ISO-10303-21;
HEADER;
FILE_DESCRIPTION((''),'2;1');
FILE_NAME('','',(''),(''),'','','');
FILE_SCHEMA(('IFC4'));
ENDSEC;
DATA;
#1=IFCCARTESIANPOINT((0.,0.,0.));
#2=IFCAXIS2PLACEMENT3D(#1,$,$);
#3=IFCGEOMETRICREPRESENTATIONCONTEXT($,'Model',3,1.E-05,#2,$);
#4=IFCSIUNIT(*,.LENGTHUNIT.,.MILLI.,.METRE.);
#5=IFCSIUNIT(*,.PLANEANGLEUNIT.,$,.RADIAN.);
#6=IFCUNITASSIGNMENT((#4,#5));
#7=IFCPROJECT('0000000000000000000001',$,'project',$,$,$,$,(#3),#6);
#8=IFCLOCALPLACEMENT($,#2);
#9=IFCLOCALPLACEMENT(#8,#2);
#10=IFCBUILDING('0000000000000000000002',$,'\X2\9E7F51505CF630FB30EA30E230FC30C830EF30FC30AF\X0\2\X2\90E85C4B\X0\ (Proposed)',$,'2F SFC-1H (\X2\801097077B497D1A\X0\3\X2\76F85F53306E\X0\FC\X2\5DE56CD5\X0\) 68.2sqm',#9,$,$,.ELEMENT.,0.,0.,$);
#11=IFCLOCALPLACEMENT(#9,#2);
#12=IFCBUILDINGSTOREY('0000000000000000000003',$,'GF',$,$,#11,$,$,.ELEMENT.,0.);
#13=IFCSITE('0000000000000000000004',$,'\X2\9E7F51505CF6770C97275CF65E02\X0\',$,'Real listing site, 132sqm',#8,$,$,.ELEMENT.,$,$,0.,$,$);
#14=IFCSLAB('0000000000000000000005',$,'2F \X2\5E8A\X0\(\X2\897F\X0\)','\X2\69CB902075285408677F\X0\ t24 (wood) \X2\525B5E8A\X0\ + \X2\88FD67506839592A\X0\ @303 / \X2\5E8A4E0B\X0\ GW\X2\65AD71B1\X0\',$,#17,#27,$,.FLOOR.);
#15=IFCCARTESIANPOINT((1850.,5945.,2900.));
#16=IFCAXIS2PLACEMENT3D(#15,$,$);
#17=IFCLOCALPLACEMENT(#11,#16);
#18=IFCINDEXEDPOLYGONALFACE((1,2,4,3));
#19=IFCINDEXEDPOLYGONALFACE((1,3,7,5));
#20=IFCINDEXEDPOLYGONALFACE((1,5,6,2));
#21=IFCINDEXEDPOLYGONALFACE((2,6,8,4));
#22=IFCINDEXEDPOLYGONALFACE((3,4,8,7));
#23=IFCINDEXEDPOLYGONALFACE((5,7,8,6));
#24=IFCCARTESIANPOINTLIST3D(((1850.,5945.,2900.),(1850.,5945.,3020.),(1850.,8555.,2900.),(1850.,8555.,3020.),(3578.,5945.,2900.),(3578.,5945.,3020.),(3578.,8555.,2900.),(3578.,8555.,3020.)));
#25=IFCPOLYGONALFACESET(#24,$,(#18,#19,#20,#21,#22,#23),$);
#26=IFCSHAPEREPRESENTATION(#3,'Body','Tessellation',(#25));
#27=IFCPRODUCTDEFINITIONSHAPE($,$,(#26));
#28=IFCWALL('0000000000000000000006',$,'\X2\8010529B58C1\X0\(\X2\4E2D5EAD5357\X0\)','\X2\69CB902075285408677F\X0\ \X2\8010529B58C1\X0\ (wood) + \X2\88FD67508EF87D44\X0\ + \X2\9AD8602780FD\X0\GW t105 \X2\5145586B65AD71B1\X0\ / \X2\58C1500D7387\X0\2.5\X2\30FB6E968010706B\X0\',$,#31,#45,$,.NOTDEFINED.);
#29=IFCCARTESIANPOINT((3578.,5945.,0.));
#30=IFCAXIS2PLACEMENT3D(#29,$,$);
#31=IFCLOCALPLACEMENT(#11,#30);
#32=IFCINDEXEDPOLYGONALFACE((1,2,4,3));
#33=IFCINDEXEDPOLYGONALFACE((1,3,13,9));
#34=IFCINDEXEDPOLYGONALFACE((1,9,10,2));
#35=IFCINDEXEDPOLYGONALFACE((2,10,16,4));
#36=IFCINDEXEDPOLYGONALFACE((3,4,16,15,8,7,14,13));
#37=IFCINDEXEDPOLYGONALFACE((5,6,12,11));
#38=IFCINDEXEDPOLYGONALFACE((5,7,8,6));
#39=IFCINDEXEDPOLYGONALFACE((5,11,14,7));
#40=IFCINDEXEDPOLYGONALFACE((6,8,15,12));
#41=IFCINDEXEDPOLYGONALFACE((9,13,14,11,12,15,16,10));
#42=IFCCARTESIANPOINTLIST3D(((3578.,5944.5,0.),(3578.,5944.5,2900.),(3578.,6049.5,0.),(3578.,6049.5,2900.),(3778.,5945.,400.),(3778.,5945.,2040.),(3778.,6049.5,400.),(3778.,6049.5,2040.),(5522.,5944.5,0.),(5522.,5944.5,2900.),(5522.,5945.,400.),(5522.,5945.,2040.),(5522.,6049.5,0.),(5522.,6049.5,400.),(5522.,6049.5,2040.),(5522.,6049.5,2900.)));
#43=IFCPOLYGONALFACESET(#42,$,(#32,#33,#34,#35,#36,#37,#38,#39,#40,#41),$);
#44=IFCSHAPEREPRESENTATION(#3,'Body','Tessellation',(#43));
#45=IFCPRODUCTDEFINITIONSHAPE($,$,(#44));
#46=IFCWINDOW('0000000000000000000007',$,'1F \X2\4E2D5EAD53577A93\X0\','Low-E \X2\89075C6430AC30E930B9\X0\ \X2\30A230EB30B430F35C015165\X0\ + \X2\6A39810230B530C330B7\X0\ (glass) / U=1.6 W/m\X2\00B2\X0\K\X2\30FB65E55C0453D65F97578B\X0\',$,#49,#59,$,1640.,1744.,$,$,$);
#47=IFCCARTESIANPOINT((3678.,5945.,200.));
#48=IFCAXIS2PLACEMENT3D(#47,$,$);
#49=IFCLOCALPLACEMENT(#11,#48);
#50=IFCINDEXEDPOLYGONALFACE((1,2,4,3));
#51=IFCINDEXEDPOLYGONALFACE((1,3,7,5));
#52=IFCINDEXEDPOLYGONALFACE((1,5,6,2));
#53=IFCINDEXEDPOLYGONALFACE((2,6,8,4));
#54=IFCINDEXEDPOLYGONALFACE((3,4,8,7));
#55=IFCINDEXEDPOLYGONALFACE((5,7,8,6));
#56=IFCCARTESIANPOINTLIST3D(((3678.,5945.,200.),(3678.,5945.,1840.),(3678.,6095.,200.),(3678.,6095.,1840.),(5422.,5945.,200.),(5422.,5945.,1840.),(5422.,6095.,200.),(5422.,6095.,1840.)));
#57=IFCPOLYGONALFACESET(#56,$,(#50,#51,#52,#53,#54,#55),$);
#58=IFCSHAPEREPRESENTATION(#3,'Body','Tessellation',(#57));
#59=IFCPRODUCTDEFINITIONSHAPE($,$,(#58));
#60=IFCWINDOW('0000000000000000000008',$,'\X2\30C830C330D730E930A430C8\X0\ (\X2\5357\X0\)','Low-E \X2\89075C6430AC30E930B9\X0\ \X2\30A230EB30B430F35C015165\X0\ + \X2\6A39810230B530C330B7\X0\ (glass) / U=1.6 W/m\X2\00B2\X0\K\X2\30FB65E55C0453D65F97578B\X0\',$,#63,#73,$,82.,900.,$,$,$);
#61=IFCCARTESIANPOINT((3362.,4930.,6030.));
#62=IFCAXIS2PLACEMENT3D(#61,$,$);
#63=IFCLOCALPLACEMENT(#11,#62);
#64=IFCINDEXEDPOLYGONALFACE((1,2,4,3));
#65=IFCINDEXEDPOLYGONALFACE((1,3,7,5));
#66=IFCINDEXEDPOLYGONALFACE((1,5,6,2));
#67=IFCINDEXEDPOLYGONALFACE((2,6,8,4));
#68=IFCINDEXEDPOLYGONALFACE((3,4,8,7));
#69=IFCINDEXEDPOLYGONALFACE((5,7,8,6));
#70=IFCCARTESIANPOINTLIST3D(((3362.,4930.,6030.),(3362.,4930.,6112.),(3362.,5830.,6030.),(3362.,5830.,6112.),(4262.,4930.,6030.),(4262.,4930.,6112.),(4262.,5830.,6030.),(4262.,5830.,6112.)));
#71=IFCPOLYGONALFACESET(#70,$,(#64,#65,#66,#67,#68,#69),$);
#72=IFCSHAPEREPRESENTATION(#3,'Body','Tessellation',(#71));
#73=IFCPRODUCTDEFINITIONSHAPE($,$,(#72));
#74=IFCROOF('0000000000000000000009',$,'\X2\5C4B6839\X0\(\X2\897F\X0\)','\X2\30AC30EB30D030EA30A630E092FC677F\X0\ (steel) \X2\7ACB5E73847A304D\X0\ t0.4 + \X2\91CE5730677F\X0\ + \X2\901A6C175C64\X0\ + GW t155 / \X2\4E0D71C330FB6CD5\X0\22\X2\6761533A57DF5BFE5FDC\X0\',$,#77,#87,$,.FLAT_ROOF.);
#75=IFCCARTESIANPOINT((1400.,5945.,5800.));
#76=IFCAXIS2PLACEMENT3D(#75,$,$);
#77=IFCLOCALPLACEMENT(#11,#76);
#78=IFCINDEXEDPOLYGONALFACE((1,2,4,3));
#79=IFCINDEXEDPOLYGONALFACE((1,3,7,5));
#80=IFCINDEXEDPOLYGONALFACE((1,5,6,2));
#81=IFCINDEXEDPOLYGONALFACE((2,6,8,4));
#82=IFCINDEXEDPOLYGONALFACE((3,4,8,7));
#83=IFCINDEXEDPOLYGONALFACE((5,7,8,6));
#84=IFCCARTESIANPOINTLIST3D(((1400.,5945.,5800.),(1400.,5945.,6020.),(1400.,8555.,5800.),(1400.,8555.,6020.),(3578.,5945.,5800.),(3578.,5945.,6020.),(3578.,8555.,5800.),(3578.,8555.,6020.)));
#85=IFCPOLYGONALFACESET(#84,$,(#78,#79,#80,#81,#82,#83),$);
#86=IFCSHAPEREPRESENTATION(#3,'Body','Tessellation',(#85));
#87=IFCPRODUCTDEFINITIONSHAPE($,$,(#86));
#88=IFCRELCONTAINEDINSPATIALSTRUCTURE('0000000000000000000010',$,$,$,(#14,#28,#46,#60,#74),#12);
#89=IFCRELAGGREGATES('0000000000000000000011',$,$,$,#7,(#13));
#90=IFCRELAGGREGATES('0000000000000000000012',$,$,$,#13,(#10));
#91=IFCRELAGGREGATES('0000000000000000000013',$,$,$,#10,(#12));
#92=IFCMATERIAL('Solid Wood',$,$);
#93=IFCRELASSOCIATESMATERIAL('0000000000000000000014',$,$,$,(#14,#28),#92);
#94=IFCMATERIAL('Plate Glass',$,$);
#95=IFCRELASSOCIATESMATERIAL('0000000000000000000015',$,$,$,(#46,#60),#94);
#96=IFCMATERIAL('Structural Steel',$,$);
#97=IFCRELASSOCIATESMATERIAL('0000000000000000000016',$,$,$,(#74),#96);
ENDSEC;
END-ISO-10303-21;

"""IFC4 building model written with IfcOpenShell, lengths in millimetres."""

from ifc_helpers import new_model, si_unit, frame, frame_2d, origin, place, context, project, spatial, rectangle, extrude, material, element, fill, save


model = new_model("IFC4")

# Units and contexts
model_context = context("Model", 3, precision=1e-05, world=origin())
ifc_project = project(units=[si_unit("LENGTHUNIT", "METRE", prefix="MILLI"), si_unit("PLANEANGLEUNIT", "RADIAN")], contexts=[model_context])

# Site, building, storey
site_placement = place(None, origin())
site = spatial("IfcSite", under=ifc_project, at=site_placement, Name="鹿児島県霧島市", ObjectType="Real listing site, 132sqm", CompositionType="ELEMENT", RefElevation=0.0)
building_placement = place(site_placement, origin())
building = spatial("IfcBuilding", under=site, at=building_placement, Name="鹿児島・リモートワーク2部屋 (Proposed)", ObjectType="2F SFC-1H (耐震等級3相当のFC工法) 68.2sqm", CompositionType="ELEMENT", ElevationOfRefHeight=0.0, ElevationOfTerrain=0.0)
storey_placement = place(building_placement, origin())
storey = spatial("IfcBuildingStorey", under=building, at=storey_placement, Name="GF", CompositionType="ELEMENT", Elevation=0.0)

# Shared definitions
ifc_material_1 = material(Name="Solid Wood")

# Slab
slab_1_placement = place(storey_placement, frame((1850.0, 5945.0, 2900.0)))
element("IfcSlab", 1, at=slab_1_placement, inside=storey, material=ifc_material_1, Name="2F 床(西)", Description="構造用合板 t24 (wood) 剛床 + 製材根太 @303 / 床下 GW断熱", PredefinedType="FLOOR", context=model_context, shape_type="SweptSolid", body=[
    extrude(rectangle(XDim=1728.0, YDim=2610.0, at=frame_2d((864.0, 1305.0))), frame((1850.0, 5945.0, 2900.0)), (0.0, 0.0, 1.0), 120.0),
])

# Wall, opening, window
wall_placement = place(storey_placement, frame((3578.0, 5945.0, 0.0)))
wall = element("IfcWall", 2, at=wall_placement, inside=storey, material=ifc_material_1, Name="耐力壁(中庭南)", Description="構造用合板 耐力壁 (wood) + 製材軸組 + 高性能GW t105 充填断熱 / 壁倍率2.5・準耐火", PredefinedType="NOTDEFINED", context=model_context, shape_type="SweptSolid", body=[
    extrude(rectangle(XDim=1944.0, YDim=105.0, at=frame_2d((972.0, 52.0))), frame((3578.0, 5945.0, 0.0)), (0.0, 0.0, 1.0), 2900.0),
])
opening_placement = place(storey_placement, frame((3678.0, 5945.0, 200.0)))
opening = element("IfcOpeningElement", 3, at=opening_placement, cuts=wall, PredefinedType="NOTDEFINED", context=model_context, shape_type="SweptSolid", body=[
    extrude(rectangle(XDim=1744.0, YDim=150.0, at=frame_2d((872.0, 75.0))), frame((3678.0, 5945.0, 200.0)), (0.0, 0.0, 1.0), 1640.0),
])
ifc_material_2 = material(Name="Plate Glass")
window_1_placement = place(storey_placement, frame((3678.0, 5945.0, 200.0)))
window_1 = element("IfcWindow", 4, at=window_1_placement, inside=storey, material=ifc_material_2, Name="1F 中庭南窓", Description="Low-E 複層ガラス アルゴン封入 + 樹脂サッシ (glass) / U=1.6 W/m²K・日射取得型", OverallHeight=1640.0, OverallWidth=1744.0, context=model_context, shape_type="SweptSolid", body=[
    extrude(rectangle(XDim=1744.0, YDim=150.0, at=frame_2d((872.0, 75.0))), frame((3678.0, 5945.0, 200.0)), (0.0, 0.0, 1.0), 1640.0),
])
fill(opening, window_1)

# Window
window_2_placement = place(storey_placement, frame((3362.0, 4930.0, 6030.0)))
element("IfcWindow", 5, at=window_2_placement, inside=storey, material=ifc_material_2, Name="トップライト (南)", Description="Low-E 複層ガラス アルゴン封入 + 樹脂サッシ (glass) / U=1.6 W/m²K・日射取得型", OverallHeight=82.0, OverallWidth=900.0, context=model_context, shape_type="SweptSolid", body=[
    extrude(rectangle(XDim=900.0, YDim=900.0, at=frame_2d((450.0, 450.0))), frame((3362.0, 4930.0, 6030.0)), (0.0, 0.0, 1.0), 82.0),
])

# Roof
ifc_material_3 = material(Name="Structural Steel")
for number, where, name in (
    (6, (1400.0, 5945.0, 5800.0), "屋根(西)"),
):
    element("IfcRoof", number, at=place(storey_placement, frame(where)), inside=storey, material=ifc_material_3, Name=name, Description="ガルバリウム鋼板 (steel) 立平葺き t0.4 + 野地板 + 通気層 + GW t155 / 不燃・法22条区域対応", PredefinedType="FLAT_ROOF", context=model_context, shape_type="SweptSolid", body=[
        extrude(rectangle(XDim=2178.0, YDim=2610.0, at=frame_2d((1089.0, 1305.0))), frame((1400.0, 5945.0, 5800.0)), (0.0, 0.0, 1.0), 220.0),
    ])

save(model, "model.ifc")
